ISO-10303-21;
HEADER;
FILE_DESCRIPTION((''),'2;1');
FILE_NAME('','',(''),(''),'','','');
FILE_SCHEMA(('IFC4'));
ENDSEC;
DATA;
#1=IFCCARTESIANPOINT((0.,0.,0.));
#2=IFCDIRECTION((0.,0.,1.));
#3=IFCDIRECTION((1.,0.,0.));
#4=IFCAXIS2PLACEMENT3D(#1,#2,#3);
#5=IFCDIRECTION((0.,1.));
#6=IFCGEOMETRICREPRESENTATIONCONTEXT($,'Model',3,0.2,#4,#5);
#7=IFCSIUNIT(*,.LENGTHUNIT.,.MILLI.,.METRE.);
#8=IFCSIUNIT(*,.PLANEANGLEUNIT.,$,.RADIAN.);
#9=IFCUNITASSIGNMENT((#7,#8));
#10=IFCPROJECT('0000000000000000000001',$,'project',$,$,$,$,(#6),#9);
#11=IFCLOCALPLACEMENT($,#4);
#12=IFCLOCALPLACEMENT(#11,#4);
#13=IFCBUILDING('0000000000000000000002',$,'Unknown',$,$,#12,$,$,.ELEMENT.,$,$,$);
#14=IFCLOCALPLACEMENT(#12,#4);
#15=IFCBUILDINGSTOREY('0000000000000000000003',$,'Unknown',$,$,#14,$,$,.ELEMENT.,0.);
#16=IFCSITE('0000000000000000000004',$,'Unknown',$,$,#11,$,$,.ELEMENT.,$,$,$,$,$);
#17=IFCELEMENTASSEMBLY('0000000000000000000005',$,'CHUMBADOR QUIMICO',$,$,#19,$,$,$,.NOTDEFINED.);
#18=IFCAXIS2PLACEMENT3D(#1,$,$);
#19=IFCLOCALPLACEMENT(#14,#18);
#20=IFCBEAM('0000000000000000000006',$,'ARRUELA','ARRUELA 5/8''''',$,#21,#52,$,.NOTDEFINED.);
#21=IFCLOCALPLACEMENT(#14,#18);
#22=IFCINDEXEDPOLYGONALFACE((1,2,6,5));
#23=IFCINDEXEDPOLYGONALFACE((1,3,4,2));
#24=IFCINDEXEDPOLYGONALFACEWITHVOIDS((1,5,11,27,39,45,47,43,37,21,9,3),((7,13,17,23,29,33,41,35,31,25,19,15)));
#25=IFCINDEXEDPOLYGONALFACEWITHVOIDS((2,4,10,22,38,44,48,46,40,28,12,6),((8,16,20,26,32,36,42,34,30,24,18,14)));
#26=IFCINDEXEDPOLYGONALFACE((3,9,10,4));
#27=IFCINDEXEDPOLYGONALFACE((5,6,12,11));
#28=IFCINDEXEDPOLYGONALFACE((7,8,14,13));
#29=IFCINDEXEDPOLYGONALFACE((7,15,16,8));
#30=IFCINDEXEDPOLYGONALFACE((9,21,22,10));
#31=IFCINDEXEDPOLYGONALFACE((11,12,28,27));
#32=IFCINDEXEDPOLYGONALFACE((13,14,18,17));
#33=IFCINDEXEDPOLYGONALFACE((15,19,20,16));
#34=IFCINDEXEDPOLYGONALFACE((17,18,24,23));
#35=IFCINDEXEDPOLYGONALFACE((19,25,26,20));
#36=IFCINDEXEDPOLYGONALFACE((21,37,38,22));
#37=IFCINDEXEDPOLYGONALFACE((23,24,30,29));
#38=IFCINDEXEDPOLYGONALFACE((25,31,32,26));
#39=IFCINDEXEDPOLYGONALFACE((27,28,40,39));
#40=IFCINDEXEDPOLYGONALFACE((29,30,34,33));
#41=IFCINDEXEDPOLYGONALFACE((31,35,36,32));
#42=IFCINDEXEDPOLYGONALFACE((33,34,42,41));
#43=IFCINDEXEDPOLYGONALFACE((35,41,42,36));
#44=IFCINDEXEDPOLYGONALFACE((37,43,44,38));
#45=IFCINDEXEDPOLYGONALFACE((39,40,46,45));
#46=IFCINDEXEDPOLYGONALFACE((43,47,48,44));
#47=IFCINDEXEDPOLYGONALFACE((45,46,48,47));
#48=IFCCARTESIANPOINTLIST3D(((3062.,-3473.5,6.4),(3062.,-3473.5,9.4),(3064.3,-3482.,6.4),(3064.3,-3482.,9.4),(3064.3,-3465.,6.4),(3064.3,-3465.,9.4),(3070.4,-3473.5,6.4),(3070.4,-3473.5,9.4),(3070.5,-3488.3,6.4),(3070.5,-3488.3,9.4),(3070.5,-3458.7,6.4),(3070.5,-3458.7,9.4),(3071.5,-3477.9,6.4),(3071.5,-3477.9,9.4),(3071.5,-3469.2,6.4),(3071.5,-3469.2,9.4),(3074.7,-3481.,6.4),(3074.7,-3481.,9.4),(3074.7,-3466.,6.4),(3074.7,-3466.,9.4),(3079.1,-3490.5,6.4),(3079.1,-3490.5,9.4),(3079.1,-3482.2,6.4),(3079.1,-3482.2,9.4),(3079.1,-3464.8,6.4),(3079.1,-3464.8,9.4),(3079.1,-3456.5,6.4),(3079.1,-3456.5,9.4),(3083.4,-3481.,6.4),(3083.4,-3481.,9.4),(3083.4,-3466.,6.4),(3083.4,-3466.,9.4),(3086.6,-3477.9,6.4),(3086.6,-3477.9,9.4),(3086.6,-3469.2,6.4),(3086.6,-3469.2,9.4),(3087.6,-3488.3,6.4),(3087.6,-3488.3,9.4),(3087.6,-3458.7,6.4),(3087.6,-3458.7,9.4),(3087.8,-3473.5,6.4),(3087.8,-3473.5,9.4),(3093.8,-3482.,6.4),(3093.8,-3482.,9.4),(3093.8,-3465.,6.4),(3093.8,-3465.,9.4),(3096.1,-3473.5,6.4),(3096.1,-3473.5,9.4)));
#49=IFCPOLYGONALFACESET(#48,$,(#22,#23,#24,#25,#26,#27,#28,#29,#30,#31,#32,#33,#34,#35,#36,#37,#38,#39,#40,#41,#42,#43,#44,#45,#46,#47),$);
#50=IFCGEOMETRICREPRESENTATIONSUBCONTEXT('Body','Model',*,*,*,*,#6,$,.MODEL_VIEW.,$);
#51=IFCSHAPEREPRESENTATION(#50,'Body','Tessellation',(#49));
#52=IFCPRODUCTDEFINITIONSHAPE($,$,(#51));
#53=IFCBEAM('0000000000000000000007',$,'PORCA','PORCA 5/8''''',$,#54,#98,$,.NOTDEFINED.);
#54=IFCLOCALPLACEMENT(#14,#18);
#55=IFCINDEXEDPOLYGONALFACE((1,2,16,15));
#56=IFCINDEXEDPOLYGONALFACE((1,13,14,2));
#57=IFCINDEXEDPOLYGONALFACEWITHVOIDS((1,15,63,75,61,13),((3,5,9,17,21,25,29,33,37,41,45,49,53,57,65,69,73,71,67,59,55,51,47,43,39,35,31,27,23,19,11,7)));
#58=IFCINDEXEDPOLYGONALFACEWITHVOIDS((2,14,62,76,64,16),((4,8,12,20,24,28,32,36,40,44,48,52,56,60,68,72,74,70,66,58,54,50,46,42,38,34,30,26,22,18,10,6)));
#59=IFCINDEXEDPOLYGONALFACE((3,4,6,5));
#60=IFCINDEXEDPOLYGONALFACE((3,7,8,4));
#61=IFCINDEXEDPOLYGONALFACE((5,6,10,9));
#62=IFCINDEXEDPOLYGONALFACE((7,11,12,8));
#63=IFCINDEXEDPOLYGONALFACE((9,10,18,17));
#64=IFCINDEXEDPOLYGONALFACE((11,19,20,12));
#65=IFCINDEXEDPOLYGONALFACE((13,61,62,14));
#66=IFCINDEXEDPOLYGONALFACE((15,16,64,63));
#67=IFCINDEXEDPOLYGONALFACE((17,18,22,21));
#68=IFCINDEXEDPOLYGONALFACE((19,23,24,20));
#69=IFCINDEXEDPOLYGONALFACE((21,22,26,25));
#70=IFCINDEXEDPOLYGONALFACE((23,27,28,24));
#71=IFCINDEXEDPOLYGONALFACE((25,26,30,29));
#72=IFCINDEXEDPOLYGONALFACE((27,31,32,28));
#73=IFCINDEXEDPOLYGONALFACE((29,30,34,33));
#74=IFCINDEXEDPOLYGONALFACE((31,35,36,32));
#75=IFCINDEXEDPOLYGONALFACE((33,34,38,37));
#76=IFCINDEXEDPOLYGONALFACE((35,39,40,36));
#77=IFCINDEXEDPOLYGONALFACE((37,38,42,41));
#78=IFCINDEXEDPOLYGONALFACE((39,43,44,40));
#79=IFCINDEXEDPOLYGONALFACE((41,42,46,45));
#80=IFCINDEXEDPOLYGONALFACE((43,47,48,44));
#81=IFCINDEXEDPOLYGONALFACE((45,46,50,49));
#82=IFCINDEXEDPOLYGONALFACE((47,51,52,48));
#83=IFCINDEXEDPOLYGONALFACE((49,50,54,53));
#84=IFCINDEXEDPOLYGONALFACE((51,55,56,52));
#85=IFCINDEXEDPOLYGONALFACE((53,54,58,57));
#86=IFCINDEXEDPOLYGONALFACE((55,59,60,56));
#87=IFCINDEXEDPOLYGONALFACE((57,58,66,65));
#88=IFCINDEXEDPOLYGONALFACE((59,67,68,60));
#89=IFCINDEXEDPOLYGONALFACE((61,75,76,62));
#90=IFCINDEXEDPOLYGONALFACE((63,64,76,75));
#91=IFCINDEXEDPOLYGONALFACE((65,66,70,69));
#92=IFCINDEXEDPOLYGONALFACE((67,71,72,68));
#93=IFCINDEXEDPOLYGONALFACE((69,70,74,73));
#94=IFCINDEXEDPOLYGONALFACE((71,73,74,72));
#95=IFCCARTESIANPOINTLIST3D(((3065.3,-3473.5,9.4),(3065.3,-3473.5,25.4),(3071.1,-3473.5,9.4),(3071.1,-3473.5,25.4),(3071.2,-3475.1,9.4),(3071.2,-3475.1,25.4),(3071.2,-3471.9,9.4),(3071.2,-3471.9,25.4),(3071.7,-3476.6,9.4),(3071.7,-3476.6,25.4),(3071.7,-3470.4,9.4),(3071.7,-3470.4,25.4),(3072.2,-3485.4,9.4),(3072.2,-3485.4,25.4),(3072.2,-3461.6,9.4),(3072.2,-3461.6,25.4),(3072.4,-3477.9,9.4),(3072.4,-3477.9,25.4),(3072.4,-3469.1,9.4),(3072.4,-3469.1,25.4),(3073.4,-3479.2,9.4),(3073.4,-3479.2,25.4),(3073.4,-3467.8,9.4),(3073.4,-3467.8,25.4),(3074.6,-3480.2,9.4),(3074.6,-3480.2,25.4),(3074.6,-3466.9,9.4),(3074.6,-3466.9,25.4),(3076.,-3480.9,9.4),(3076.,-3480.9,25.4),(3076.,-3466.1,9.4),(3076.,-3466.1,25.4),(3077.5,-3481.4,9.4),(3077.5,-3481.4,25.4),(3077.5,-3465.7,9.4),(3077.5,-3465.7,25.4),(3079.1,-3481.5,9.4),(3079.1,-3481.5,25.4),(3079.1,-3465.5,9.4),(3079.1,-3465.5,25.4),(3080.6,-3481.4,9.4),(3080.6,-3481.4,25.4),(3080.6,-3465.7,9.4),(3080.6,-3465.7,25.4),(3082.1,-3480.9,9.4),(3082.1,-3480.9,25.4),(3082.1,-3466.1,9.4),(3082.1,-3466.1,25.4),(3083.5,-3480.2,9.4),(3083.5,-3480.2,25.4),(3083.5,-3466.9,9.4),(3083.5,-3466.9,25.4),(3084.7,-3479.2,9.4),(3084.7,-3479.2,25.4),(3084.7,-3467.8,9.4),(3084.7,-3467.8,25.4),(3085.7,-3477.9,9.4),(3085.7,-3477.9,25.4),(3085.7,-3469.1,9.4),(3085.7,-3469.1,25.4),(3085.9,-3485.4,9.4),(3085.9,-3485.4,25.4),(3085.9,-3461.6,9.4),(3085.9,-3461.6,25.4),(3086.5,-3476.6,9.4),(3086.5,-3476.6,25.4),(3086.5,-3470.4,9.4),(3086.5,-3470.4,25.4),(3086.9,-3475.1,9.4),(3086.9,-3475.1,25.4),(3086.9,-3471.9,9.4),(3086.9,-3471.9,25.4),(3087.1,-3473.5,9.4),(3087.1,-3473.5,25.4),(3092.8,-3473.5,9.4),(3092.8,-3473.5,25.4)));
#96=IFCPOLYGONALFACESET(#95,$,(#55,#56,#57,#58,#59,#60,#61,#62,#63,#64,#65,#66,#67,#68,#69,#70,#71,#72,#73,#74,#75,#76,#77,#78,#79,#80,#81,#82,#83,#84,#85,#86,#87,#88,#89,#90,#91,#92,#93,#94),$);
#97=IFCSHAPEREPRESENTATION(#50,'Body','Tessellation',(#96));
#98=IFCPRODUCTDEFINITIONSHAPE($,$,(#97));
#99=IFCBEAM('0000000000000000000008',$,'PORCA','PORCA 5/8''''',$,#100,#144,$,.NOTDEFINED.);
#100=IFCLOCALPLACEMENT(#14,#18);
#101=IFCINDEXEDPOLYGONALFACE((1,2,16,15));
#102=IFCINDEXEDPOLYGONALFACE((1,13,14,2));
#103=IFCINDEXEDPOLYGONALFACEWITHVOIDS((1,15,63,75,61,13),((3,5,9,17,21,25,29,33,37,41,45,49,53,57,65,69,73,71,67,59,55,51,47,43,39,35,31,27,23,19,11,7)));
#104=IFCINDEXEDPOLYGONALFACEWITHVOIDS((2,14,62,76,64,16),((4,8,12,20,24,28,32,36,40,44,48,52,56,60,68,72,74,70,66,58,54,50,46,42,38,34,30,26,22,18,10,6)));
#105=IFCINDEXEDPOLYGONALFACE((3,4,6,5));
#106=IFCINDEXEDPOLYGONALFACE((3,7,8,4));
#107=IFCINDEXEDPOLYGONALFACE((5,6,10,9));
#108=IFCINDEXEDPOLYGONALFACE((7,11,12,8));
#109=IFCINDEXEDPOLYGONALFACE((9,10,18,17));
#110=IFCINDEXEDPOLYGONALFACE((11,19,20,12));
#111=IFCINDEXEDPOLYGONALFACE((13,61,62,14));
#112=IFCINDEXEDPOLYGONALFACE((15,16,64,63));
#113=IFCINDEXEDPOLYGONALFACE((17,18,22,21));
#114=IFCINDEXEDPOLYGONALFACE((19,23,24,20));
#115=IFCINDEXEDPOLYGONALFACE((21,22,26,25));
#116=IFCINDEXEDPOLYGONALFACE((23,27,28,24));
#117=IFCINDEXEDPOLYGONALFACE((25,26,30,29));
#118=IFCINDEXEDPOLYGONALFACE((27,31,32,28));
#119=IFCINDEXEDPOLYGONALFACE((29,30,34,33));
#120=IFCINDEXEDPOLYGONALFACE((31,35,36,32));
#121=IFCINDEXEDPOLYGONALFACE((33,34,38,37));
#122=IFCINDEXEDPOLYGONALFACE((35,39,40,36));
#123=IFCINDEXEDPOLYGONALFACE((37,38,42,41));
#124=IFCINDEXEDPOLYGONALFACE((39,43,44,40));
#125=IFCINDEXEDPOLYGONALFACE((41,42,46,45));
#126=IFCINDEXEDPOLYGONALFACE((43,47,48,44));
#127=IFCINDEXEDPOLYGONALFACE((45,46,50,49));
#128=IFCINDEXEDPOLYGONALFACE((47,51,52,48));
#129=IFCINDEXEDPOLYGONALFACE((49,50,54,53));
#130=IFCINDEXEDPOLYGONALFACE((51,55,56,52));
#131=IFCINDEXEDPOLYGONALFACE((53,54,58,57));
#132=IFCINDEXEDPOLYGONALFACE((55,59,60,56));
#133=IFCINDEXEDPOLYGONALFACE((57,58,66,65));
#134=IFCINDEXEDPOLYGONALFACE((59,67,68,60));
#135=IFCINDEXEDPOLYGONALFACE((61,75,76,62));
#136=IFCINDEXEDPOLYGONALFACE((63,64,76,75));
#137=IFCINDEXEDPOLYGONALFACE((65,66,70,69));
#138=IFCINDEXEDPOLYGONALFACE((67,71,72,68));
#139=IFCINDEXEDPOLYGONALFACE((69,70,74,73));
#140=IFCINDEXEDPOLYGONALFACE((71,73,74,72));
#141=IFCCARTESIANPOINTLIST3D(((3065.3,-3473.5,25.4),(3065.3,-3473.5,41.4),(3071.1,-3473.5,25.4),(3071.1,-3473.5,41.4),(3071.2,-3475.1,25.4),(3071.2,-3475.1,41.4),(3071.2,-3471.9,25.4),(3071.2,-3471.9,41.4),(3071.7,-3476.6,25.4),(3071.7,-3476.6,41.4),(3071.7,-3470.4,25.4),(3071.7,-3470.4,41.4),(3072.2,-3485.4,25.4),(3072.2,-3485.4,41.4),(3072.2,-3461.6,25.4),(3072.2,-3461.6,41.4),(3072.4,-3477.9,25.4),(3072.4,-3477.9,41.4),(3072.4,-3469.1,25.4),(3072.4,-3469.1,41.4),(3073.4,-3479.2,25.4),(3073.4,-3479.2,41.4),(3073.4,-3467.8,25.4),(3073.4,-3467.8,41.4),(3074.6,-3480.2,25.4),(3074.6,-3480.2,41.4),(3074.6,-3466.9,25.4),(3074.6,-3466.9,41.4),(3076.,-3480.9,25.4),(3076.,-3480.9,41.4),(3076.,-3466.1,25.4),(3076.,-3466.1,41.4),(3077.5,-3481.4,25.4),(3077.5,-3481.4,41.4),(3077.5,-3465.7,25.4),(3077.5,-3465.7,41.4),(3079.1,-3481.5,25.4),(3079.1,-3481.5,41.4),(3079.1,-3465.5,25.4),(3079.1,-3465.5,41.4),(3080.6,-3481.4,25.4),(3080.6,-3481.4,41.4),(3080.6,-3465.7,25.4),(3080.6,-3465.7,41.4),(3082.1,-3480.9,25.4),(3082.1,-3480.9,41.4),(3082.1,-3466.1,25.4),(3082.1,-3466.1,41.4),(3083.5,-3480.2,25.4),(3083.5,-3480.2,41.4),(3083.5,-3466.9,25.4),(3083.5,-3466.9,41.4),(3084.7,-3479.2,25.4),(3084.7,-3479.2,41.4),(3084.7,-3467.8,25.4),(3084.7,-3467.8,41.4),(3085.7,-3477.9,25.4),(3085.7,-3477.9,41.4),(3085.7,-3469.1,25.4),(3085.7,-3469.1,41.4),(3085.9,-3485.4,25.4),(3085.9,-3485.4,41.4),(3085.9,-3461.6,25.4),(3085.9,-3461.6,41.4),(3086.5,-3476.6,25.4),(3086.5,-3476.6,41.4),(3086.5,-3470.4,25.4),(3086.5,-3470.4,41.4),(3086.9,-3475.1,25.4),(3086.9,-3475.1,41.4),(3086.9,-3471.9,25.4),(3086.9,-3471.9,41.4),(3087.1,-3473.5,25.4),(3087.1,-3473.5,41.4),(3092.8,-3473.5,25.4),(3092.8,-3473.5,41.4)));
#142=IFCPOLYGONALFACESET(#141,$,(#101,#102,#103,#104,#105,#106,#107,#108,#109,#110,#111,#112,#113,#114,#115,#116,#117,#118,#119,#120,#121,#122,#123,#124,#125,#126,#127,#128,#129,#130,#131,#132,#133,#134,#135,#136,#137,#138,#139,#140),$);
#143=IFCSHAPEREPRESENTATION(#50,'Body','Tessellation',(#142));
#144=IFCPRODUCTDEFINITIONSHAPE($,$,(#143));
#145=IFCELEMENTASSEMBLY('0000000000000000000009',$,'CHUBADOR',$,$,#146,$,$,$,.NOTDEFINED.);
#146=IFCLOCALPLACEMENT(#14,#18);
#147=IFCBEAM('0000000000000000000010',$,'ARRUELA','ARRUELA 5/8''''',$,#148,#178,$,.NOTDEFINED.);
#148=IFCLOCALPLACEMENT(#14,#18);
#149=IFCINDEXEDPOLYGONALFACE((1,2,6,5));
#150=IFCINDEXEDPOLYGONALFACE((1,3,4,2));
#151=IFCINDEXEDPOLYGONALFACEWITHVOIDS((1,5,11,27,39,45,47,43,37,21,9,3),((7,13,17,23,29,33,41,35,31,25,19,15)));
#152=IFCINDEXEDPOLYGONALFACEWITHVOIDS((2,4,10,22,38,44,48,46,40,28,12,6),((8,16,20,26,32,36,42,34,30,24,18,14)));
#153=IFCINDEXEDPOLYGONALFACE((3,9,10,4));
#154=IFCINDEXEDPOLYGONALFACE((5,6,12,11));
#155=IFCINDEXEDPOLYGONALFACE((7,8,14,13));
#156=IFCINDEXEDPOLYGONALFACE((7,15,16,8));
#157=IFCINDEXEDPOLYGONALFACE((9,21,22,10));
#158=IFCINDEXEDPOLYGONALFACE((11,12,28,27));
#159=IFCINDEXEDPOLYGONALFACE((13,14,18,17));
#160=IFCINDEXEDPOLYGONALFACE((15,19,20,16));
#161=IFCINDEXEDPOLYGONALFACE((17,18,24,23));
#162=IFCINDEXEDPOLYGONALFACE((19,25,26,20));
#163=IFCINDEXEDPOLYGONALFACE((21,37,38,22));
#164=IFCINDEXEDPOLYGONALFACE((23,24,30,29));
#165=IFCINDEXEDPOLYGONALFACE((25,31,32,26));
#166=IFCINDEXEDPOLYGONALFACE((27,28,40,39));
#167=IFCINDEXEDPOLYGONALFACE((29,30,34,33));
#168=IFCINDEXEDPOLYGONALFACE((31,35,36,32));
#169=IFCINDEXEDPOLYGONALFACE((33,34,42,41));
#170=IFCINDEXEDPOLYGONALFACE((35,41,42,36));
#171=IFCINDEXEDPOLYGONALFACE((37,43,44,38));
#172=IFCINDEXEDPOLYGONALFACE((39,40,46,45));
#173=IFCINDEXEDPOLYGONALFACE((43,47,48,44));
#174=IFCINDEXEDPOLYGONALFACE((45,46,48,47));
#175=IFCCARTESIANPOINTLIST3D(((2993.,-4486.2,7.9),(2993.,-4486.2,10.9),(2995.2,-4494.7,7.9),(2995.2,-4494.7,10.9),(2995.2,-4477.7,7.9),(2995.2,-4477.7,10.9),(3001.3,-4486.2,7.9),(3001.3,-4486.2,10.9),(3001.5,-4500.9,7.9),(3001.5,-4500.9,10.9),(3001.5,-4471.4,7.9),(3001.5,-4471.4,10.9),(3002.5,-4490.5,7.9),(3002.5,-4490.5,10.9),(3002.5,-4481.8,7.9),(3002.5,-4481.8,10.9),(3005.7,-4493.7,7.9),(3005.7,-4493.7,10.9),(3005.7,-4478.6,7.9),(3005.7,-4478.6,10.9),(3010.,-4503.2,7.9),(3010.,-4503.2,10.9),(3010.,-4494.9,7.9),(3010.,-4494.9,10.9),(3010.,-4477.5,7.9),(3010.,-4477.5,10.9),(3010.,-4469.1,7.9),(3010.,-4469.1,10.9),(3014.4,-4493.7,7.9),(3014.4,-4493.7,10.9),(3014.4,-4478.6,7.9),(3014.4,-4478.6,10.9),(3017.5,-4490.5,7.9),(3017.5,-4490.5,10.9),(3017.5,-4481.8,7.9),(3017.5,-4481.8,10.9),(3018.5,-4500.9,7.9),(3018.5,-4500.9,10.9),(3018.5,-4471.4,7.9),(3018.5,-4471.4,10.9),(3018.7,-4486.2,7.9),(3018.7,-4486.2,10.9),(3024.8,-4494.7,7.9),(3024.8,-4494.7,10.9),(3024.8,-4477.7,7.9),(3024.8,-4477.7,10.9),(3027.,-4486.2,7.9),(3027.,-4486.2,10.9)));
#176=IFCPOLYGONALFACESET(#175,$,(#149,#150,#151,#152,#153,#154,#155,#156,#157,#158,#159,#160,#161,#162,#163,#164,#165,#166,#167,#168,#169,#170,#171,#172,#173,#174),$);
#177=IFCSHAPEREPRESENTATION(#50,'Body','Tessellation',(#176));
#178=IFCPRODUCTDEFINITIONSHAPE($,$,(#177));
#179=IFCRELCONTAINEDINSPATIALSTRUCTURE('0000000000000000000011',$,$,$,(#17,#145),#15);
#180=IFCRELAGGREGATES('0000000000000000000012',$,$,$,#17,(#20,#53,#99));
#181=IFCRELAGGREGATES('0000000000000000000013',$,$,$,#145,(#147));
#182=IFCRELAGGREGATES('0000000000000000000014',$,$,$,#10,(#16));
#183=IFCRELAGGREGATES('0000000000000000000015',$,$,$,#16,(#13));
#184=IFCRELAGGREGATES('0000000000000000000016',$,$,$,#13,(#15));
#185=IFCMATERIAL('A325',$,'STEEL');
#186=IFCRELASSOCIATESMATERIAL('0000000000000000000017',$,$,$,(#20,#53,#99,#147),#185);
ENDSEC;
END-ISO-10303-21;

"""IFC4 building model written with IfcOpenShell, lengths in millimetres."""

from ifc_helpers import new_model, si_unit, direction, frame, origin_with_axes, place, context, subcontext, project, spatial, line, indexed_curve, outline, extrude, material, element, aggregate, save


model = new_model("IFC4")

# Units and contexts
model_context = context("Model", 3, precision=0.2, world=origin_with_axes(), true_north=direction((0.0, 1.0)))
body_context = subcontext(model_context, "Body", "Model", "MODEL_VIEW")
ifc_project = project(units=[si_unit("LENGTHUNIT", "METRE", prefix="MILLI"), si_unit("PLANEANGLEUNIT", "RADIAN")], contexts=[model_context])

# Site, building, storey
site_placement = place(None, origin_with_axes())
site = spatial("IfcSite", under=ifc_project, at=site_placement, Name="Unknown", CompositionType="ELEMENT")
building_placement = place(site_placement, origin_with_axes())
building = spatial("IfcBuilding", under=site, at=building_placement, Name="Unknown", CompositionType="ELEMENT")
storey_placement = place(building_placement, origin_with_axes())
storey = spatial("IfcBuildingStorey", under=building, at=storey_placement, Name="Unknown", CompositionType="ELEMENT", Elevation=0.0)

# Element assemblies, beams
ifc_material_1 = material(Name="A325", Category="STEEL")
assembly_1_placement = place(storey_placement, frame((3079.1, -3473.5, -53.6), z_axis=(0.0, -1.0, 0.0), x_axis=(0.0, 0.0, -1.0)))
assembly_1 = element("IfcElementAssembly", 1, at=assembly_1_placement, inside=storey, Name="CHUMBADOR QUIMICO", PredefinedType="NOTDEFINED")
beam_1_placement = place(assembly_1_placement, frame((-63.0, 0.0, 0.0), z_axis=(0.0, 0.0, 1.0), x_axis=(1.0, 0.0, 0.0)))
beam_1 = element("IfcBeam", 2, at=beam_1_placement, material=ifc_material_1, Name="ARRUELA", Description="ARRUELA 5/8''", PredefinedType="NOTDEFINED", context=body_context, shape_type="SolidModel", body=[
    extrude(outline(indexed_curve([(17.0, 0.0), (14.8, 8.5), (8.5, 14.8), (0.0, 17.0), (-8.5, 14.8), (-14.8, 8.5), (-17.0, 0.0), (-14.8, -8.5), (-8.5, -14.8), (0.0, -17.0), (8.5, -14.8), (14.8, -8.5)], segments=[line(1, 2, 3, 4, 5, 6, 7, 8, 9, 10, 11, 12, 1)]), holes=[indexed_curve([(8.7, 0.0), (7.5, -4.3), (4.3, -7.5), (0.0, -8.7), (-4.3, -7.5), (-7.5, -4.3), (-8.7, 0.0), (-7.5, 4.3), (-4.3, 7.5), (0.0, 8.7), (4.3, 7.5), (7.5, 4.3)], segments=[line(1, 2, 3, 4, 5, 6, 7, 8, 9, 10, 11, 12, 1)])]), frame((0.0, 0.0, 0.0), z_axis=(-1.0, 0.0, 0.0), x_axis=(0.0, 0.0, 1.0)), (0.0, 0.0, -1.0), 3.0),
])
beam_2_placement = place(assembly_1_placement, frame((-79.0, 0.0, 0.0), z_axis=(0.0, 0.0, 1.0), x_axis=(1.0, 0.0, 0.0)))
beam_2 = element("IfcBeam", 3, at=beam_2_placement, material=ifc_material_1, Name="PORCA", Description="PORCA 5/8''", PredefinedType="NOTDEFINED", context=body_context, shape_type="SolidModel", body=[
    extrude(outline(indexed_curve([(0.0, 13.8), (-11.9, 6.9), (-11.9, -6.9), (0.0, -13.8), (11.9, -6.9), (11.9, 6.9)], segments=[line(1, 2, 3, 4, 5, 6, 1)]), holes=[indexed_curve([(7.8, 1.6), (8.0, 0.0), (7.8, -1.6), (7.4, -3.1), (6.7, -4.4), (5.7, -5.7), (4.4, -6.7), (3.1, -7.4), (1.6, -7.8), (0.0, -8.0), (-1.6, -7.8), (-3.1, -7.4), (-4.4, -6.7), (-5.7, -5.7), (-6.7, -4.4), (-7.4, -3.1), (-7.8, -1.6), (-8.0, 0.0), (-7.8, 1.6), (-7.4, 3.1), (-6.7, 4.4), (-5.7, 5.7), (-4.4, 6.7), (-3.1, 7.4), (-1.6, 7.8), (0.0, 8.0), (1.6, 7.8), (3.1, 7.4), (4.4, 6.7), (5.7, 5.7), (6.7, 4.4), (7.4, 3.1)], segments=[line(1, 2, 3, 4, 5, 6, 7, 8, 9, 10, 11, 12, 13, 14, 15, 16, 17, 18, 19, 20, 21, 22, 23, 24, 25, 26, 27, 28, 29, 30, 31, 32, 1)])]), frame((0.0, 0.0, 0.0), z_axis=(-1.0, 0.0, 0.0), x_axis=(0.0, 0.0, 1.0)), (0.0, 0.0, -1.0), 16.0),
])
beam_3_placement = place(assembly_1_placement, frame((-95.0, 0.0, 0.0), z_axis=(0.0, 0.0, 1.0), x_axis=(1.0, 0.0, 0.0)))
beam_3 = element("IfcBeam", 4, at=beam_3_placement, material=ifc_material_1, Name="PORCA", Description="PORCA 5/8''", PredefinedType="NOTDEFINED", context=body_context, shape_type="SolidModel", body=[
    extrude(outline(indexed_curve([(0.0, 13.8), (-11.9, 6.9), (-11.9, -6.9), (0.0, -13.8), (11.9, -6.9), (11.9, 6.9)], segments=[line(1, 2, 3, 4, 5, 6, 1)]), holes=[indexed_curve([(7.8, 1.6), (8.0, 0.0), (7.8, -1.6), (7.4, -3.1), (6.7, -4.4), (5.7, -5.7), (4.4, -6.7), (3.1, -7.4), (1.6, -7.8), (0.0, -8.0), (-1.6, -7.8), (-3.1, -7.4), (-4.4, -6.7), (-5.7, -5.7), (-6.7, -4.4), (-7.4, -3.1), (-7.8, -1.6), (-8.0, 0.0), (-7.8, 1.6), (-7.4, 3.1), (-6.7, 4.4), (-5.7, 5.7), (-4.4, 6.7), (-3.1, 7.4), (-1.6, 7.8), (0.0, 8.0), (1.6, 7.8), (3.1, 7.4), (4.4, 6.7), (5.7, 5.7), (6.7, 4.4), (7.4, 3.1)], segments=[line(1, 2, 3, 4, 5, 6, 7, 8, 9, 10, 11, 12, 13, 14, 15, 16, 17, 18, 19, 20, 21, 22, 23, 24, 25, 26, 27, 28, 29, 30, 31, 32, 1)])]), frame((0.0, 0.0, 0.0), z_axis=(-1.0, 0.0, 0.0), x_axis=(0.0, 0.0, 1.0)), (0.0, 0.0, -1.0), 16.0),
])
aggregate(assembly_1, [beam_1, beam_2, beam_3])
assembly_2_placement = place(storey_placement, frame((3010.0, -4486.2, -44.2), z_axis=(-1.0, 0.0, 0.0), x_axis=(0.0, 0.0, -1.0)))
assembly_2 = element("IfcElementAssembly", 5, at=assembly_2_placement, inside=storey, Name="CHUBADOR", PredefinedType="NOTDEFINED")
beam_4_placement = place(assembly_2_placement, frame((-55.1, 0.0, 0.0), z_axis=(0.0, 0.0, 1.0), x_axis=(1.0, 0.0, 0.0)))
beam_4 = element("IfcBeam", 6, at=beam_4_placement, material=ifc_material_1, Name="ARRUELA", Description="ARRUELA 5/8''", PredefinedType="NOTDEFINED", context=body_context, shape_type="SolidModel", body=[
    extrude(outline(indexed_curve([(17.0, 0.0), (14.8, 8.5), (8.5, 14.8), (0.0, 17.0), (-8.5, 14.8), (-14.8, 8.5), (-17.0, 0.0), (-14.8, -8.5), (-8.5, -14.8), (0.0, -17.0), (8.5, -14.8), (14.8, -8.5)], segments=[line(1, 2, 3, 4, 5, 6, 7, 8, 9, 10, 11, 12, 1)]), holes=[indexed_curve([(8.7, 0.0), (7.5, -4.3), (4.3, -7.5), (0.0, -8.7), (-4.3, -7.5), (-7.5, -4.3), (-8.7, 0.0), (-7.5, 4.3), (-4.3, 7.5), (0.0, 8.7), (4.3, 7.5), (7.5, 4.3)], segments=[line(1, 2, 3, 4, 5, 6, 7, 8, 9, 10, 11, 12, 1)])]), frame((0.0, 0.0, 0.0), z_axis=(-1.0, 0.0, 0.0), x_axis=(0.0, 0.0, 1.0)), (0.0, 0.0, -1.0), 3.0),
])
aggregate(assembly_2, [beam_4])

save(model, "model.ifc")
